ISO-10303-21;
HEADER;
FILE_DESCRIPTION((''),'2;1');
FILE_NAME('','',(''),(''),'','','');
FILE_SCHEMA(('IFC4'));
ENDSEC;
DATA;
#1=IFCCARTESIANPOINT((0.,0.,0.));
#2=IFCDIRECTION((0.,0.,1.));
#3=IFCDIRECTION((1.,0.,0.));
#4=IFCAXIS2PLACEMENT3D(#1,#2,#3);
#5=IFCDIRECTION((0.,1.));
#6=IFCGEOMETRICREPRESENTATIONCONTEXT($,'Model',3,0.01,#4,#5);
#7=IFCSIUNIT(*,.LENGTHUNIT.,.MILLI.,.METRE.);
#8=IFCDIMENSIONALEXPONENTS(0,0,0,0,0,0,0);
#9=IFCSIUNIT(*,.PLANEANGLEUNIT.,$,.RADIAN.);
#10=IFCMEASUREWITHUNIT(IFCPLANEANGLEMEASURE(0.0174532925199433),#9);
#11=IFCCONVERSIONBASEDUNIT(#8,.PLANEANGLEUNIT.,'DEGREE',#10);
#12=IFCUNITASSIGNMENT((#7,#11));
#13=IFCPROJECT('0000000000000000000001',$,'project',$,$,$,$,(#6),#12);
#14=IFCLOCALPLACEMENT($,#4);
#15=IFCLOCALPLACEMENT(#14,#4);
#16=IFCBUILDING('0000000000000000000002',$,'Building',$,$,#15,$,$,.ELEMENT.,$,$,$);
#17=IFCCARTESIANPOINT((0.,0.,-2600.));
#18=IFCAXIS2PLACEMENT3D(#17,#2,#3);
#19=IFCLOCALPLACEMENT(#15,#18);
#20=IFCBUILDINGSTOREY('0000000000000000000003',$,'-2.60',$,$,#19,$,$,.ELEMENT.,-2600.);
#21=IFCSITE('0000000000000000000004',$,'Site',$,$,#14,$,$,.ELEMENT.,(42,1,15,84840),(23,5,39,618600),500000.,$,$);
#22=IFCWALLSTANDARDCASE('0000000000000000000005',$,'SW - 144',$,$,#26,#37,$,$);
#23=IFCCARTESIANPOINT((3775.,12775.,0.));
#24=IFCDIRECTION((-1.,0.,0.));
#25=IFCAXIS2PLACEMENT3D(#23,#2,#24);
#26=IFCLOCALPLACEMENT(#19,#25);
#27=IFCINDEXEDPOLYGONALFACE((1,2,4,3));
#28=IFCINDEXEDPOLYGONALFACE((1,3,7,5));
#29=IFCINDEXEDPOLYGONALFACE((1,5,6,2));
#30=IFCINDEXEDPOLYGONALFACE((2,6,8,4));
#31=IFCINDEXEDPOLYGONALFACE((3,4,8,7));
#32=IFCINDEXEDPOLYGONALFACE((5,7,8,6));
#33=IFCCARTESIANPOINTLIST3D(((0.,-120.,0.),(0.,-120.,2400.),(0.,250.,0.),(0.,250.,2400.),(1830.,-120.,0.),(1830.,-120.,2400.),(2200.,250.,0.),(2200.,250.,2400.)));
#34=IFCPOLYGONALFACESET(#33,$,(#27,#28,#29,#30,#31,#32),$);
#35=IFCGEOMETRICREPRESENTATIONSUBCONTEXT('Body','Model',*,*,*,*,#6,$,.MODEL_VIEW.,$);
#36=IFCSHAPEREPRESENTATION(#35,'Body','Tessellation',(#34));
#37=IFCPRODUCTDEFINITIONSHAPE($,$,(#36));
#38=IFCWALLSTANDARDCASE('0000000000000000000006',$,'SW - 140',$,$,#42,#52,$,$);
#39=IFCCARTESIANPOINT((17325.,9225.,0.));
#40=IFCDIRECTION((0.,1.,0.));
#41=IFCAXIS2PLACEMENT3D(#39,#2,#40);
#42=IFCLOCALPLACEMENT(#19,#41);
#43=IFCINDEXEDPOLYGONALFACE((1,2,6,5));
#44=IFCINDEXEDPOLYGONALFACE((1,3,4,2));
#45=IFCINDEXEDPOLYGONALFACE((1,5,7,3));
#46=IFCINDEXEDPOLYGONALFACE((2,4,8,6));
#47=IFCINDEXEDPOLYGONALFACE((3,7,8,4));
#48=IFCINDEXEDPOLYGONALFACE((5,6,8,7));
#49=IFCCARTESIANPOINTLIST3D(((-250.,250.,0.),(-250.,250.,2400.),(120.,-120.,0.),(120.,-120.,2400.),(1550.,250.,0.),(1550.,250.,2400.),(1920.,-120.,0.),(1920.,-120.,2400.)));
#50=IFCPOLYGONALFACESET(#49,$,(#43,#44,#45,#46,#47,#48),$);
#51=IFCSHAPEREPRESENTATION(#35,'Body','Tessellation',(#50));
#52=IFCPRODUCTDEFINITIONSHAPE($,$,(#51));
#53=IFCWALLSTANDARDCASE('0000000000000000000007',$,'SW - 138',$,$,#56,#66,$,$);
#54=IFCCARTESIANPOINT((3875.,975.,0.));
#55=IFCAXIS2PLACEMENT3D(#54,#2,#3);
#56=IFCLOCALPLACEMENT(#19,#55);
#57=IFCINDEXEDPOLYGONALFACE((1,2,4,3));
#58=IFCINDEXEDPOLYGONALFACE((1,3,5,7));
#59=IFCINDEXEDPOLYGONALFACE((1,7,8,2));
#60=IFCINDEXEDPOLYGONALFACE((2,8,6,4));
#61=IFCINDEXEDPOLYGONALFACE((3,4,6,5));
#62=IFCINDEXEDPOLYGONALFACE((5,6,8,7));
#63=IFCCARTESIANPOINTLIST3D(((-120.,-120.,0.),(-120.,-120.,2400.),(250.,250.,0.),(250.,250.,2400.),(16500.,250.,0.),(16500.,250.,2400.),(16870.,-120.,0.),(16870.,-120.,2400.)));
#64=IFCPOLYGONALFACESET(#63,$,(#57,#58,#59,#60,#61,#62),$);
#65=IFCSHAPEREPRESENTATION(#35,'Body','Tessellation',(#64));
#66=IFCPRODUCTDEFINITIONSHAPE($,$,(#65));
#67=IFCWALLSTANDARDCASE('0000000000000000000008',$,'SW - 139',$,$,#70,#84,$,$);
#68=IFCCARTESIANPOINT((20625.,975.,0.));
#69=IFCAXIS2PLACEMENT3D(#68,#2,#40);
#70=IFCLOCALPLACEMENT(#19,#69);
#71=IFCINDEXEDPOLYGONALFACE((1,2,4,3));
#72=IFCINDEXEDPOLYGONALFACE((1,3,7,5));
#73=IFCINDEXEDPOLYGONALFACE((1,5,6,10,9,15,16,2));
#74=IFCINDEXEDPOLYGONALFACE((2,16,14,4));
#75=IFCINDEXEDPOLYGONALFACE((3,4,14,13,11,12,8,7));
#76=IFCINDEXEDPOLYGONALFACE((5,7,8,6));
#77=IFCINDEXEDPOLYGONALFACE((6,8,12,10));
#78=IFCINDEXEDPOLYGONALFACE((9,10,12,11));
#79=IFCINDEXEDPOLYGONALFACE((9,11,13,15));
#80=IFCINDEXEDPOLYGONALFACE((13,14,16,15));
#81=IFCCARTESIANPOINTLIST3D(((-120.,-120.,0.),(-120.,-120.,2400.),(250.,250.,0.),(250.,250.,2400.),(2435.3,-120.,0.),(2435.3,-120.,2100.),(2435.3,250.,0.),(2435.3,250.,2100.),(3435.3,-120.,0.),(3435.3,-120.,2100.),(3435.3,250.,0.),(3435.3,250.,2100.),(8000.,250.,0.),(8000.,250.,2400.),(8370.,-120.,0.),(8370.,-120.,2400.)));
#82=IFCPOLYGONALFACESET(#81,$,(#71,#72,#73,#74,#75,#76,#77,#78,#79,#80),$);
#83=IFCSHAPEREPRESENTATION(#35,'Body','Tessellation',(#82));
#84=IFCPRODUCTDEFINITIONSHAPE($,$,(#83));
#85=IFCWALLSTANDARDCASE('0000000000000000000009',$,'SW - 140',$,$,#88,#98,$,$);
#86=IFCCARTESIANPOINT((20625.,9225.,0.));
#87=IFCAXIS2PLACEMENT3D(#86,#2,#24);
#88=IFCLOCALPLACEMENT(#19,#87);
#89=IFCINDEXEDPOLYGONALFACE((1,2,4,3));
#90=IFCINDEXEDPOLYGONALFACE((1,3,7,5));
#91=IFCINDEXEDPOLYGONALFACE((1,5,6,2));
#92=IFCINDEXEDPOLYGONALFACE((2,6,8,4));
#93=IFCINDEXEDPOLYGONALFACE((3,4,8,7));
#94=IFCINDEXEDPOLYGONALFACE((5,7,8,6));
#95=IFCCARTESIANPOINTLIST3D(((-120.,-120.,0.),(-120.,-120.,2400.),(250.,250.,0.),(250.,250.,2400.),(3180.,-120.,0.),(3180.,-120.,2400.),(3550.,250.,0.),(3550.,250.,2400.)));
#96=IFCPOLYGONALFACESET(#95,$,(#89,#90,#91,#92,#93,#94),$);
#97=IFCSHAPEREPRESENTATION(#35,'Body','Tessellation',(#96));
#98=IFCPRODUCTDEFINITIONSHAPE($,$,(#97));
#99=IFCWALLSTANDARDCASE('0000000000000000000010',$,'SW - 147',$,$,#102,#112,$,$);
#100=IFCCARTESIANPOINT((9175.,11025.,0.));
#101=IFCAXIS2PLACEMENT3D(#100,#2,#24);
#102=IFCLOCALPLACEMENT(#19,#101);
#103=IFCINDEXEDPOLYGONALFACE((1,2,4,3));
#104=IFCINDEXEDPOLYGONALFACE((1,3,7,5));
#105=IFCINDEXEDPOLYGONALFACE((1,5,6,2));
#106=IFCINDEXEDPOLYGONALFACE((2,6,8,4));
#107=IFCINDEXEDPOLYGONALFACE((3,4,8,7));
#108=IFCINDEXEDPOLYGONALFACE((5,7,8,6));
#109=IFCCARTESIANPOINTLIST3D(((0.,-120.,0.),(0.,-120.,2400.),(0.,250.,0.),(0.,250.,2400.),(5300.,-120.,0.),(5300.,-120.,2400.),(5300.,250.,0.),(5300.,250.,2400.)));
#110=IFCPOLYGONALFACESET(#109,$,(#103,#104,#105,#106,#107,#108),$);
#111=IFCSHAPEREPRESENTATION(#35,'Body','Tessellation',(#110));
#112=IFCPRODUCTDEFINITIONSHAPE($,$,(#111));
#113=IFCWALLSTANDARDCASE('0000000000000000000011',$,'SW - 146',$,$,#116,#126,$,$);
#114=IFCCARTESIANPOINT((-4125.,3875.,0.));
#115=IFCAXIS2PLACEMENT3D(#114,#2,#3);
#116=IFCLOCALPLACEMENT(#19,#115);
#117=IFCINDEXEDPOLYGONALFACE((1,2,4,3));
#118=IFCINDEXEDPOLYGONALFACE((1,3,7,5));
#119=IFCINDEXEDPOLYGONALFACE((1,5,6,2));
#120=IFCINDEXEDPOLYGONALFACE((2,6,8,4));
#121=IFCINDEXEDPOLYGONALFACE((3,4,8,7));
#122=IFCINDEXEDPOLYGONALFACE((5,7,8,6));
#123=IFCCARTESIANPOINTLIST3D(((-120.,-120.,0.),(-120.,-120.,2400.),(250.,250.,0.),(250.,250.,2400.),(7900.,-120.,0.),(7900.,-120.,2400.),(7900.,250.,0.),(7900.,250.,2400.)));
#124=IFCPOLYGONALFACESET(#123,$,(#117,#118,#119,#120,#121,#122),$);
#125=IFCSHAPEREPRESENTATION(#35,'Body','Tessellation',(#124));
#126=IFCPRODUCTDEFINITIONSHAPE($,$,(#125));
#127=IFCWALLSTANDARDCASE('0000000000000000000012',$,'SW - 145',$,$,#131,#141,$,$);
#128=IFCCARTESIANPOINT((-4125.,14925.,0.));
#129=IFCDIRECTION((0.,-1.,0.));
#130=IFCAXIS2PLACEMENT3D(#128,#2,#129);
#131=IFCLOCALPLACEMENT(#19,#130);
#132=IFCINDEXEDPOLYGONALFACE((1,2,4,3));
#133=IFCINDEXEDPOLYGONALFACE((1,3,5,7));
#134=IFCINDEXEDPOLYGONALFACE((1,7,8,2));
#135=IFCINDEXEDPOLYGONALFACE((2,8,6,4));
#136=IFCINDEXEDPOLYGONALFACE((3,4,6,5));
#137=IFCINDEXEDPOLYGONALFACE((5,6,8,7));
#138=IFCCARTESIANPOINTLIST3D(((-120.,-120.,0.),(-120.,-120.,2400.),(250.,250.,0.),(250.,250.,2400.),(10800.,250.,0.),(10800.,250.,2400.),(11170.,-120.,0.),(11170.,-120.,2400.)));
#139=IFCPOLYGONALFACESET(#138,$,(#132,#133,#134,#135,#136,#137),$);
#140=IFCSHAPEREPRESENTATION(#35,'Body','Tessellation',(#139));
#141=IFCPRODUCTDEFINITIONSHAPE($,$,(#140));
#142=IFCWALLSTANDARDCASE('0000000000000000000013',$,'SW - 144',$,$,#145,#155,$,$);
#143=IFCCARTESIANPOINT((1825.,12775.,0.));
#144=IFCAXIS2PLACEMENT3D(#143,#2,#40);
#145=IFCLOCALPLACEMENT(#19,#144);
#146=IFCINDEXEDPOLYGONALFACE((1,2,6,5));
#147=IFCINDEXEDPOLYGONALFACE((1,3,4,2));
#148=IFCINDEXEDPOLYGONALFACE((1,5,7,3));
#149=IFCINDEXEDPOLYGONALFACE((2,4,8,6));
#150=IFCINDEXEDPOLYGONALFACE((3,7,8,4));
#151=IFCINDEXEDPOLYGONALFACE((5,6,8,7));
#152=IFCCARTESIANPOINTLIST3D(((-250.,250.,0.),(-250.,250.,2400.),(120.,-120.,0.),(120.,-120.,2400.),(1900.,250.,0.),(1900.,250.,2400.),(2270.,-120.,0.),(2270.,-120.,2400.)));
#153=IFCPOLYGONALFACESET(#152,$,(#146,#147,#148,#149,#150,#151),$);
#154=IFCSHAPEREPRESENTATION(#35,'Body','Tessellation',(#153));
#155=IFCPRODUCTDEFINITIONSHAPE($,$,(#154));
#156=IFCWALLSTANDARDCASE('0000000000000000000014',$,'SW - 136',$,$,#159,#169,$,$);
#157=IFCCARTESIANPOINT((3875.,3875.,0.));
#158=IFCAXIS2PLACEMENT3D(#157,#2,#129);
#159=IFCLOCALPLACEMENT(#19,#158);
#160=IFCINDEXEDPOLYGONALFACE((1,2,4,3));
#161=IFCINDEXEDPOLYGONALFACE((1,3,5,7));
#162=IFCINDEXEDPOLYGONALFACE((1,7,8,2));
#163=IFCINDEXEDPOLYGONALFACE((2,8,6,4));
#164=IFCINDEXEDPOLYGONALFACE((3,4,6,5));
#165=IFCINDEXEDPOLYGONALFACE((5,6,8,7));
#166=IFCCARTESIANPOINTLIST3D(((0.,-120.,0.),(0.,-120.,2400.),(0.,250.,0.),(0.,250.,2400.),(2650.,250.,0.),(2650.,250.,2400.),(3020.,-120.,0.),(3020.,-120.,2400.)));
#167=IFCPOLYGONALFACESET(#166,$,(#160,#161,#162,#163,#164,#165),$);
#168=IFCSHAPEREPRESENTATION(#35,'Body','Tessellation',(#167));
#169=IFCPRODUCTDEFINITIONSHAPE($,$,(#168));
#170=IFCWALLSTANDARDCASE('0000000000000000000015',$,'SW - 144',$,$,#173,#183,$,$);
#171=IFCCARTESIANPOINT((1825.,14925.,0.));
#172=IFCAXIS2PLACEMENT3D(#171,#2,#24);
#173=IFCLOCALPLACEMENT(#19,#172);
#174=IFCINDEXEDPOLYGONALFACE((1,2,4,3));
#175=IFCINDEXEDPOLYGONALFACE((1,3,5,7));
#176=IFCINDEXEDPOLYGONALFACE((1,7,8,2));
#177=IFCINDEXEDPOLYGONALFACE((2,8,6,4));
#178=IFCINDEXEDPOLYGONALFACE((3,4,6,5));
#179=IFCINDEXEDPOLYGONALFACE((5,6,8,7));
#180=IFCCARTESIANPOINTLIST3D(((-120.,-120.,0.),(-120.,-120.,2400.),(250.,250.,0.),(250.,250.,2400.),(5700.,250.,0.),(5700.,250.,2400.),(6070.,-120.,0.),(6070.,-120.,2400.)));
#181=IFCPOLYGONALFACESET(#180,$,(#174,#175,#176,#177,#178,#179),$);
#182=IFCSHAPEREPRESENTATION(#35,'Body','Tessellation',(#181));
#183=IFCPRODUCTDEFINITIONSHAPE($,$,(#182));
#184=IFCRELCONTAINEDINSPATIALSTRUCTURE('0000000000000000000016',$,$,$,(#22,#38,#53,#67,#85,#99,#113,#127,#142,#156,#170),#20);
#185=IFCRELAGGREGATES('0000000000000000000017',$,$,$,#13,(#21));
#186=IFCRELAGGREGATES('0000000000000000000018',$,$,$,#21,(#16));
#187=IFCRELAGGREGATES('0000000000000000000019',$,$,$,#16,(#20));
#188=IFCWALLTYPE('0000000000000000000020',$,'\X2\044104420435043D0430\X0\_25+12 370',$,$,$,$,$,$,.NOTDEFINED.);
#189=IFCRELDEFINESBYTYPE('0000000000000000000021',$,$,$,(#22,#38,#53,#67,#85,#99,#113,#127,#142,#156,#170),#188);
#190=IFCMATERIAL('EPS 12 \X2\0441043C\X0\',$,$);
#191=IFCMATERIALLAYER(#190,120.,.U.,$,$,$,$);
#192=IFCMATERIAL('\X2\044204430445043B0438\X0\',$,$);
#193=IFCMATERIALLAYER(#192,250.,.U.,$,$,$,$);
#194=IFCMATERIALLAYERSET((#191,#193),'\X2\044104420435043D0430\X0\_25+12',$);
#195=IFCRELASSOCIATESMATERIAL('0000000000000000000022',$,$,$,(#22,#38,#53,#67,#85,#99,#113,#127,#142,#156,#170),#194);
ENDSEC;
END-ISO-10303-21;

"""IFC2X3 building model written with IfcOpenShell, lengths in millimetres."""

from ifc_helpers import new_model, entity, si_unit, converted_unit, direction, frame, origin_with_axes, origin_2d_with_axis, place, context, subcontext, project, spatial, polyline, rectangle, outline, extrude, material, layer, layer_set, layer_usage, type_object, element, save


model = new_model("IFC2X3")

# Units and contexts
model_context = context("Model", 3, precision=0.01, world=origin_with_axes(), true_north=direction((0.0, 1.0)))
body_context = subcontext(model_context, "Body", "Model", "MODEL_VIEW")
ifc_project = project(units=[si_unit("LENGTHUNIT", "METRE", prefix="MILLI"), converted_unit("PLANEANGLEUNIT", "DEGREE", entity("IfcPlaneAngleMeasure", 0.0174532925199433), si_unit("PLANEANGLEUNIT", "RADIAN"), dimensions=[0, 0, 0, 0, 0, 0, 0])], contexts=[model_context])

# Site, building, storey
site_placement = place(None, origin_with_axes())
site = spatial("IfcSite", under=ifc_project, at=site_placement, Name="Site", CompositionType="ELEMENT", RefLatitude=(42, 1, 15, 84840), RefLongitude=(23, 5, 39, 618600), RefElevation=500000.0)
building_placement = place(site_placement, origin_with_axes())
building = spatial("IfcBuilding", under=site, at=building_placement, Name="Building", CompositionType="ELEMENT")
storey_placement = place(building_placement, frame((0.0, 0.0, -2600.0), z_axis=(0.0, 0.0, 1.0), x_axis=(1.0, 0.0, 0.0)))
storey = spatial("IfcBuildingStorey", under=building, at=storey_placement, Name="-2.60", CompositionType="ELEMENT", Elevation=-2600.0)

# Walls
ifc_material_1 = material(Name="EPS 12 см")
ifc_layer_1 = layer(ifc_material_1, 120.0, ventilated="UNKNOWN")
ifc_material_2 = material(Name="тухли")
ifc_layer_2 = layer(ifc_material_2, 250.0, ventilated="UNKNOWN")
ifc_layer_set_1 = layer_set([ifc_layer_1, ifc_layer_2], Name="стена_25+12")
ifc_layer_usage_1 = layer_usage(ifc_layer_set_1, "AXIS2", "POSITIVE", -120.0)
wall_type_1 = type_object("IfcWallType", Name="стена_25+12 370", PredefinedType="NOTDEFINED")
wall_1_placement = place(storey_placement, frame((3775.0, 12775.0, 0.0), z_axis=(0.0, 0.0, 1.0), x_axis=(-1.0, 0.0, 0.0)))
element("IfcWallStandardCase", 1, at=wall_1_placement, inside=storey, type_object=wall_type_1, material=ifc_layer_usage_1, Name="SW - 144", context=body_context, shape_type="SweptSolid", body=[
    extrude(outline(polyline([(0.0, -120.0), (1830.0, -120.0), (2200.0, 250.0), (0.0, 250.0), (0.0, -120.0)])), origin_with_axes(), (0.0, 0.0, 1.0), 2400.0),
])
ifc_layer_usage_2 = layer_usage(ifc_layer_set_1, "AXIS2", "POSITIVE", -120.0)
wall_2_placement = place(storey_placement, frame((17325.0, 9225.0, 0.0), z_axis=(0.0, 0.0, 1.0), x_axis=(0.0, 1.0, 0.0)))
element("IfcWallStandardCase", 2, at=wall_2_placement, inside=storey, type_object=wall_type_1, material=ifc_layer_usage_2, Name="SW - 140", context=body_context, shape_type="SweptSolid", body=[
    extrude(outline(polyline([(120.0, -120.0), (1920.0, -120.0), (1550.0, 250.0), (-250.0, 250.0), (120.0, -120.0)])), origin_with_axes(), (0.0, 0.0, 1.0), 2400.0),
])
ifc_layer_usage_3 = layer_usage(ifc_layer_set_1, "AXIS2", "POSITIVE", -120.0)
wall_3_placement = place(storey_placement, frame((3875.0, 975.0, 0.0), z_axis=(0.0, 0.0, 1.0), x_axis=(1.0, 0.0, 0.0)))
element("IfcWallStandardCase", 3, at=wall_3_placement, inside=storey, type_object=wall_type_1, material=ifc_layer_usage_3, Name="SW - 138", context=body_context, shape_type="SweptSolid", body=[
    extrude(outline(polyline([(-120.0, -120.0), (16870.0, -120.0), (16500.0, 250.0), (250.0, 250.0), (-120.0, -120.0)])), origin_with_axes(), (0.0, 0.0, 1.0), 2400.0),
])

# Wall, opening
ifc_layer_usage_4 = layer_usage(ifc_layer_set_1, "AXIS2", "POSITIVE", -120.0)
wall_4_placement = place(storey_placement, frame((20625.0, 975.0, 0.0), z_axis=(0.0, 0.0, 1.0), x_axis=(0.0, 1.0, 0.0)))
wall_4 = element("IfcWallStandardCase", 4, at=wall_4_placement, inside=storey, type_object=wall_type_1, material=ifc_layer_usage_4, Name="SW - 139", context=body_context, shape_type="SweptSolid", body=[
    extrude(outline(polyline([(-120.0, -120.0), (8370.0, -120.0), (8000.0, 250.0), (250.0, 250.0), (-120.0, -120.0)])), origin_with_axes(), (0.0, 0.0, 1.0), 2400.0),
])
opening_1_placement = place(wall_4_placement, frame((2935.3, 0.0, 0.0), z_axis=(0.0, 0.0, 1.0), x_axis=(1.0, 0.0, 0.0)))
element("IfcOpeningElement", 5, at=opening_1_placement, cuts=wall_4, context=body_context, shape_type="SweptSolid", body=[
    extrude(rectangle(XDim=1000.0, YDim=2100.0, at=origin_2d_with_axis()), frame((0.0, 370.0, 1050.0), z_axis=(0.0, -1.0, 0.0), x_axis=(-1.0, 0.0, 0.0)), (0.0, 0.0, 1.0), 1110.0),
])

# Walls
ifc_layer_usage_5 = layer_usage(ifc_layer_set_1, "AXIS2", "POSITIVE", -120.0)
wall_5_placement = place(storey_placement, frame((20625.0, 9225.0, 0.0), z_axis=(0.0, 0.0, 1.0), x_axis=(-1.0, 0.0, 0.0)))
element("IfcWallStandardCase", 6, at=wall_5_placement, inside=storey, type_object=wall_type_1, material=ifc_layer_usage_5, Name="SW - 140", context=body_context, shape_type="SweptSolid", body=[
    extrude(outline(polyline([(-120.0, -120.0), (3180.0, -120.0), (3550.0, 250.0), (250.0, 250.0), (-120.0, -120.0)])), origin_with_axes(), (0.0, 0.0, 1.0), 2400.0),
])
ifc_layer_usage_6 = layer_usage(ifc_layer_set_1, "AXIS2", "POSITIVE", -120.0)
wall_6_placement = place(storey_placement, frame((9175.0, 11025.0, 0.0), z_axis=(0.0, 0.0, 1.0), x_axis=(-1.0, 0.0, 0.0)))
element("IfcWallStandardCase", 7, at=wall_6_placement, inside=storey, type_object=wall_type_1, material=ifc_layer_usage_6, Name="SW - 147", context=body_context, shape_type="SweptSolid", body=[
    extrude(outline(polyline([(0.0, -120.0), (5300.0, -120.0), (5300.0, 250.0), (0.0, 250.0), (0.0, -120.0)])), origin_with_axes(), (0.0, 0.0, 1.0), 2400.0),
])
ifc_layer_usage_7 = layer_usage(ifc_layer_set_1, "AXIS2", "POSITIVE", -120.0)
wall_7_placement = place(storey_placement, frame((-4125.0, 3875.0, 0.0), z_axis=(0.0, 0.0, 1.0), x_axis=(1.0, 0.0, 0.0)))
element("IfcWallStandardCase", 8, at=wall_7_placement, inside=storey, type_object=wall_type_1, material=ifc_layer_usage_7, Name="SW - 146", context=body_context, shape_type="SweptSolid", body=[
    extrude(outline(polyline([(-120.0, -120.0), (7900.0, -120.0), (7900.0, 250.0), (250.0, 250.0), (-120.0, -120.0)])), origin_with_axes(), (0.0, 0.0, 1.0), 2400.0),
])
ifc_layer_usage_8 = layer_usage(ifc_layer_set_1, "AXIS2", "POSITIVE", -120.0)
wall_8_placement = place(storey_placement, frame((-4125.0, 14925.0, 0.0), z_axis=(0.0, 0.0, 1.0), x_axis=(0.0, -1.0, 0.0)))
element("IfcWallStandardCase", 9, at=wall_8_placement, inside=storey, type_object=wall_type_1, material=ifc_layer_usage_8, Name="SW - 145", context=body_context, shape_type="SweptSolid", body=[
    extrude(outline(polyline([(-120.0, -120.0), (11170.0, -120.0), (10800.0, 250.0), (250.0, 250.0), (-120.0, -120.0)])), origin_with_axes(), (0.0, 0.0, 1.0), 2400.0),
])
ifc_layer_usage_9 = layer_usage(ifc_layer_set_1, "AXIS2", "POSITIVE", -120.0)
wall_9_placement = place(storey_placement, frame((1825.0, 12775.0, 0.0), z_axis=(0.0, 0.0, 1.0), x_axis=(0.0, 1.0, 0.0)))
element("IfcWallStandardCase", 10, at=wall_9_placement, inside=storey, type_object=wall_type_1, material=ifc_layer_usage_9, Name="SW - 144", context=body_context, shape_type="SweptSolid", body=[
    extrude(outline(polyline([(120.0, -120.0), (2270.0, -120.0), (1900.0, 250.0), (-250.0, 250.0), (120.0, -120.0)])), origin_with_axes(), (0.0, 0.0, 1.0), 2400.0),
])
ifc_layer_usage_10 = layer_usage(ifc_layer_set_1, "AXIS2", "POSITIVE", -120.0)
wall_10_placement = place(storey_placement, frame((3875.0, 3875.0, 0.0), z_axis=(0.0, 0.0, 1.0), x_axis=(0.0, -1.0, 0.0)))
element("IfcWallStandardCase", 11, at=wall_10_placement, inside=storey, type_object=wall_type_1, material=ifc_layer_usage_10, Name="SW - 136", context=body_context, shape_type="SweptSolid", body=[
    extrude(outline(polyline([(0.0, -120.0), (3020.0, -120.0), (2650.0, 250.0), (0.0, 250.0), (0.0, -120.0)])), origin_with_axes(), (0.0, 0.0, 1.0), 2400.0),
])
ifc_layer_usage_11 = layer_usage(ifc_layer_set_1, "AXIS2", "POSITIVE", -120.0)
wall_11_placement = place(storey_placement, frame((1825.0, 14925.0, 0.0), z_axis=(0.0, 0.0, 1.0), x_axis=(-1.0, 0.0, 0.0)))
element("IfcWallStandardCase", 12, at=wall_11_placement, inside=storey, type_object=wall_type_1, material=ifc_layer_usage_11, Name="SW - 144", context=body_context, shape_type="SweptSolid", body=[
    extrude(outline(polyline([(-120.0, -120.0), (6070.0, -120.0), (5700.0, 250.0), (250.0, 250.0), (-120.0, -120.0)])), origin_with_axes(), (0.0, 0.0, 1.0), 2400.0),
])

save(model, "model.ifc")
